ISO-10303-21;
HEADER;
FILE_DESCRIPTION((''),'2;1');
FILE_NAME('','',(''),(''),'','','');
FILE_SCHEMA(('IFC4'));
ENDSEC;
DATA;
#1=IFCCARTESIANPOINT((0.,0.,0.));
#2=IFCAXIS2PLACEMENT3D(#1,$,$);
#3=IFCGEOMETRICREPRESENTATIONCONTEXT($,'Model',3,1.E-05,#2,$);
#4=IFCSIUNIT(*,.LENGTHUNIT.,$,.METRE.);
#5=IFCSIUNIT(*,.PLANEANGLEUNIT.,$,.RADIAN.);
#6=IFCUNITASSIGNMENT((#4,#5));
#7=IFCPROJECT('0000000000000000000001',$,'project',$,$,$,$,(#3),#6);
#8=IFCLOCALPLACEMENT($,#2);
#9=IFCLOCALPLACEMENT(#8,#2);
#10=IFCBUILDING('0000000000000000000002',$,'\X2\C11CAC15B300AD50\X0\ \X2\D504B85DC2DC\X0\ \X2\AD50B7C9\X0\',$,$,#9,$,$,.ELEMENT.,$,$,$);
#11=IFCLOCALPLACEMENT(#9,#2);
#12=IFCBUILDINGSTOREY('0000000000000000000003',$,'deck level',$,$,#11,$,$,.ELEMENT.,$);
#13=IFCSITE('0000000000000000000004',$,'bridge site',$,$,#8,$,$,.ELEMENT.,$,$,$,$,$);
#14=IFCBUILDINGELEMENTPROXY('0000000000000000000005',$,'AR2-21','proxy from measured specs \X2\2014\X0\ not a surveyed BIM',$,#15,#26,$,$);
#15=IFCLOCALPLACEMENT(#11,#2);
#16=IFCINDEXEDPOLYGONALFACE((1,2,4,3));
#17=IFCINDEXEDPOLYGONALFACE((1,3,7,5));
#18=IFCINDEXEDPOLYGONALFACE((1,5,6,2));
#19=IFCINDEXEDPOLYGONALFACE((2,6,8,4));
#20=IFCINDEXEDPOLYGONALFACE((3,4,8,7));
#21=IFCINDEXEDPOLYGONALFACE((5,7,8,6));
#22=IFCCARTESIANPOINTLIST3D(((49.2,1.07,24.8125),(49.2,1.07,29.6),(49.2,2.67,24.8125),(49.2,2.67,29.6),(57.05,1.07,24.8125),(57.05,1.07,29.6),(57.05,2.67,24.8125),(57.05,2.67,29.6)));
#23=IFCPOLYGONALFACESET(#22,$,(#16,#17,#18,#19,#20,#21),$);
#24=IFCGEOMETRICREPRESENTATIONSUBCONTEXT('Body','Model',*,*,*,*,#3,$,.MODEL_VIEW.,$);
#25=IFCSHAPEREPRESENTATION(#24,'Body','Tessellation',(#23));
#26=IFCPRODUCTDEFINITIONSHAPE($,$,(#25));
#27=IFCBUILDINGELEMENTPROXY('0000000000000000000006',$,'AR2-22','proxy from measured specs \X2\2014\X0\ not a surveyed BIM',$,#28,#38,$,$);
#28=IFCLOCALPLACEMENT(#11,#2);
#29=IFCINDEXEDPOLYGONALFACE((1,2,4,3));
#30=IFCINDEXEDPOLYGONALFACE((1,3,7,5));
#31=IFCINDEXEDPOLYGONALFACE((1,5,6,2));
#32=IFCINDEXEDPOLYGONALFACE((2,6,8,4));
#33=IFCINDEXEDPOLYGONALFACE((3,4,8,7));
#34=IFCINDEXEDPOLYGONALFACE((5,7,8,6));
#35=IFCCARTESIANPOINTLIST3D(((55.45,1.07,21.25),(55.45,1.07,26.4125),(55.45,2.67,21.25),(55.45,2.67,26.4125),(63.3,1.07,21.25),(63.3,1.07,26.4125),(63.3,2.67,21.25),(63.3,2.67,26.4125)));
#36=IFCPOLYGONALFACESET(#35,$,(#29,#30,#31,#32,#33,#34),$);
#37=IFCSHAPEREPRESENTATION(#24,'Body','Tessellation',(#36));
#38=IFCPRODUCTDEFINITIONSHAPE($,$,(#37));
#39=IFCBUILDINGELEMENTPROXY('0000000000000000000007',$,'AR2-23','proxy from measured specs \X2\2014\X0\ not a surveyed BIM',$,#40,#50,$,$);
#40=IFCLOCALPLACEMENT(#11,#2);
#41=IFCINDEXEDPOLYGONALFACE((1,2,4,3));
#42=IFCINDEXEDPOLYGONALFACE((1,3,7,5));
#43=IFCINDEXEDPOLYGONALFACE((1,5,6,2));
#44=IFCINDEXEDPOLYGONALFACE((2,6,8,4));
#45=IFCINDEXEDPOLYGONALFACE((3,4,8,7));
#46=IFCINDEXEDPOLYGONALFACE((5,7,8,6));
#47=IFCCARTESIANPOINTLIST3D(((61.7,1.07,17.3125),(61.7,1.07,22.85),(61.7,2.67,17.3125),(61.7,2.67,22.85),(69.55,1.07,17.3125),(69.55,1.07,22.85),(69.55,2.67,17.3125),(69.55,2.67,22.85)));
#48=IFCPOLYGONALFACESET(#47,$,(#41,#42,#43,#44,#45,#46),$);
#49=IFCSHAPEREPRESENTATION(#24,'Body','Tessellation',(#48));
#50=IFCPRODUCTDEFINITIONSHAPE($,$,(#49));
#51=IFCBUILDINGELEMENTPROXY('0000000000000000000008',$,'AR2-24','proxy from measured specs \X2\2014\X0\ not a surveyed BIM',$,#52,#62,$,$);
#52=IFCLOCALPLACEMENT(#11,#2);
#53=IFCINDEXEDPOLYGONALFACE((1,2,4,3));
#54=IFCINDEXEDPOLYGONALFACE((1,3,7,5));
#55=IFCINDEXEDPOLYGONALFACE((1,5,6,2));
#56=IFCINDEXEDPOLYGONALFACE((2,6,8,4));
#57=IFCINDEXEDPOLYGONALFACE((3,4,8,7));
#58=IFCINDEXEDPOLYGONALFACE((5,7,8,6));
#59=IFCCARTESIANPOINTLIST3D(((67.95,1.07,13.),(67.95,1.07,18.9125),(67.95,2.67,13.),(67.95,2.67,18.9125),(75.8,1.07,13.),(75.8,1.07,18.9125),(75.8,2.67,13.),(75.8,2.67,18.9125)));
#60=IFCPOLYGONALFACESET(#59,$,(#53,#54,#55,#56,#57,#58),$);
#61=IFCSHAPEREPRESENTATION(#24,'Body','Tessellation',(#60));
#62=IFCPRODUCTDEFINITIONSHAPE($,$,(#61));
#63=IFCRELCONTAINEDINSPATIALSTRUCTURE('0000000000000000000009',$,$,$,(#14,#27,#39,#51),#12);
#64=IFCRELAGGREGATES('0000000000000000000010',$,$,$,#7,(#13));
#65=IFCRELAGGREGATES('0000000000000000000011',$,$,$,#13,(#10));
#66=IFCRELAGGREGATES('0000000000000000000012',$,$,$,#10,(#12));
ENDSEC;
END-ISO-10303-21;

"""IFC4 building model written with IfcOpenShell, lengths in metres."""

from ifc_helpers import new_model, si_unit, frame, origin, origin_2d, place, context, subcontext, project, spatial, rectangle, extrude, element, save


model = new_model("IFC4")

# Units and contexts
model_context = context("Model", 3, precision=1e-05, world=origin())
body_context = subcontext(model_context, "Body", "Model", "MODEL_VIEW")
ifc_project = project(units=[si_unit("LENGTHUNIT", "METRE"), si_unit("PLANEANGLEUNIT", "RADIAN")], contexts=[model_context])

# Site, building, storey
site_placement = place(None, origin())
site = spatial("IfcSite", under=ifc_project, at=site_placement, Name="bridge site", CompositionType="ELEMENT")
building_placement = place(site_placement, origin())
building = spatial("IfcBuilding", under=site, at=building_placement, Name="서강대교 프록시 교량", CompositionType="ELEMENT")
storey_placement = place(building_placement, origin())
storey = spatial("IfcBuildingStorey", under=building, at=storey_placement, Name="deck level", CompositionType="ELEMENT")

# Building element proxies
proxy_1_placement = place(storey_placement, frame((53.125, 1.87, 24.8125)))
element("IfcBuildingElementProxy", 1, at=proxy_1_placement, inside=storey, Name="AR2-21", Description="proxy from measured specs — not a surveyed BIM", context=body_context, shape_type="SweptSolid", body=[
    extrude(rectangle(XDim=7.85, YDim=1.6, at=origin_2d()), origin(), (0.0, 0.0, 1.0), 4.7875),
])
proxy_2_placement = place(storey_placement, frame((59.375, 1.87, 21.25)))
element("IfcBuildingElementProxy", 2, at=proxy_2_placement, inside=storey, Name="AR2-22", Description="proxy from measured specs — not a surveyed BIM", context=body_context, shape_type="SweptSolid", body=[
    extrude(rectangle(XDim=7.85, YDim=1.6, at=origin_2d()), origin(), (0.0, 0.0, 1.0), 5.1625),
])
proxy_3_placement = place(storey_placement, frame((65.625, 1.87, 17.3125)))
element("IfcBuildingElementProxy", 3, at=proxy_3_placement, inside=storey, Name="AR2-23", Description="proxy from measured specs — not a surveyed BIM", context=body_context, shape_type="SweptSolid", body=[
    extrude(rectangle(XDim=7.85, YDim=1.6, at=origin_2d()), origin(), (0.0, 0.0, 1.0), 5.5375),
])
proxy_4_placement = place(storey_placement, frame((71.875, 1.87, 13.0)))
element("IfcBuildingElementProxy", 4, at=proxy_4_placement, inside=storey, Name="AR2-24", Description="proxy from measured specs — not a surveyed BIM", context=body_context, shape_type="SweptSolid", body=[
    extrude(rectangle(XDim=7.85, YDim=1.6, at=origin_2d()), origin(), (0.0, 0.0, 1.0), 5.9125),
])

save(model, "model.ifc")
